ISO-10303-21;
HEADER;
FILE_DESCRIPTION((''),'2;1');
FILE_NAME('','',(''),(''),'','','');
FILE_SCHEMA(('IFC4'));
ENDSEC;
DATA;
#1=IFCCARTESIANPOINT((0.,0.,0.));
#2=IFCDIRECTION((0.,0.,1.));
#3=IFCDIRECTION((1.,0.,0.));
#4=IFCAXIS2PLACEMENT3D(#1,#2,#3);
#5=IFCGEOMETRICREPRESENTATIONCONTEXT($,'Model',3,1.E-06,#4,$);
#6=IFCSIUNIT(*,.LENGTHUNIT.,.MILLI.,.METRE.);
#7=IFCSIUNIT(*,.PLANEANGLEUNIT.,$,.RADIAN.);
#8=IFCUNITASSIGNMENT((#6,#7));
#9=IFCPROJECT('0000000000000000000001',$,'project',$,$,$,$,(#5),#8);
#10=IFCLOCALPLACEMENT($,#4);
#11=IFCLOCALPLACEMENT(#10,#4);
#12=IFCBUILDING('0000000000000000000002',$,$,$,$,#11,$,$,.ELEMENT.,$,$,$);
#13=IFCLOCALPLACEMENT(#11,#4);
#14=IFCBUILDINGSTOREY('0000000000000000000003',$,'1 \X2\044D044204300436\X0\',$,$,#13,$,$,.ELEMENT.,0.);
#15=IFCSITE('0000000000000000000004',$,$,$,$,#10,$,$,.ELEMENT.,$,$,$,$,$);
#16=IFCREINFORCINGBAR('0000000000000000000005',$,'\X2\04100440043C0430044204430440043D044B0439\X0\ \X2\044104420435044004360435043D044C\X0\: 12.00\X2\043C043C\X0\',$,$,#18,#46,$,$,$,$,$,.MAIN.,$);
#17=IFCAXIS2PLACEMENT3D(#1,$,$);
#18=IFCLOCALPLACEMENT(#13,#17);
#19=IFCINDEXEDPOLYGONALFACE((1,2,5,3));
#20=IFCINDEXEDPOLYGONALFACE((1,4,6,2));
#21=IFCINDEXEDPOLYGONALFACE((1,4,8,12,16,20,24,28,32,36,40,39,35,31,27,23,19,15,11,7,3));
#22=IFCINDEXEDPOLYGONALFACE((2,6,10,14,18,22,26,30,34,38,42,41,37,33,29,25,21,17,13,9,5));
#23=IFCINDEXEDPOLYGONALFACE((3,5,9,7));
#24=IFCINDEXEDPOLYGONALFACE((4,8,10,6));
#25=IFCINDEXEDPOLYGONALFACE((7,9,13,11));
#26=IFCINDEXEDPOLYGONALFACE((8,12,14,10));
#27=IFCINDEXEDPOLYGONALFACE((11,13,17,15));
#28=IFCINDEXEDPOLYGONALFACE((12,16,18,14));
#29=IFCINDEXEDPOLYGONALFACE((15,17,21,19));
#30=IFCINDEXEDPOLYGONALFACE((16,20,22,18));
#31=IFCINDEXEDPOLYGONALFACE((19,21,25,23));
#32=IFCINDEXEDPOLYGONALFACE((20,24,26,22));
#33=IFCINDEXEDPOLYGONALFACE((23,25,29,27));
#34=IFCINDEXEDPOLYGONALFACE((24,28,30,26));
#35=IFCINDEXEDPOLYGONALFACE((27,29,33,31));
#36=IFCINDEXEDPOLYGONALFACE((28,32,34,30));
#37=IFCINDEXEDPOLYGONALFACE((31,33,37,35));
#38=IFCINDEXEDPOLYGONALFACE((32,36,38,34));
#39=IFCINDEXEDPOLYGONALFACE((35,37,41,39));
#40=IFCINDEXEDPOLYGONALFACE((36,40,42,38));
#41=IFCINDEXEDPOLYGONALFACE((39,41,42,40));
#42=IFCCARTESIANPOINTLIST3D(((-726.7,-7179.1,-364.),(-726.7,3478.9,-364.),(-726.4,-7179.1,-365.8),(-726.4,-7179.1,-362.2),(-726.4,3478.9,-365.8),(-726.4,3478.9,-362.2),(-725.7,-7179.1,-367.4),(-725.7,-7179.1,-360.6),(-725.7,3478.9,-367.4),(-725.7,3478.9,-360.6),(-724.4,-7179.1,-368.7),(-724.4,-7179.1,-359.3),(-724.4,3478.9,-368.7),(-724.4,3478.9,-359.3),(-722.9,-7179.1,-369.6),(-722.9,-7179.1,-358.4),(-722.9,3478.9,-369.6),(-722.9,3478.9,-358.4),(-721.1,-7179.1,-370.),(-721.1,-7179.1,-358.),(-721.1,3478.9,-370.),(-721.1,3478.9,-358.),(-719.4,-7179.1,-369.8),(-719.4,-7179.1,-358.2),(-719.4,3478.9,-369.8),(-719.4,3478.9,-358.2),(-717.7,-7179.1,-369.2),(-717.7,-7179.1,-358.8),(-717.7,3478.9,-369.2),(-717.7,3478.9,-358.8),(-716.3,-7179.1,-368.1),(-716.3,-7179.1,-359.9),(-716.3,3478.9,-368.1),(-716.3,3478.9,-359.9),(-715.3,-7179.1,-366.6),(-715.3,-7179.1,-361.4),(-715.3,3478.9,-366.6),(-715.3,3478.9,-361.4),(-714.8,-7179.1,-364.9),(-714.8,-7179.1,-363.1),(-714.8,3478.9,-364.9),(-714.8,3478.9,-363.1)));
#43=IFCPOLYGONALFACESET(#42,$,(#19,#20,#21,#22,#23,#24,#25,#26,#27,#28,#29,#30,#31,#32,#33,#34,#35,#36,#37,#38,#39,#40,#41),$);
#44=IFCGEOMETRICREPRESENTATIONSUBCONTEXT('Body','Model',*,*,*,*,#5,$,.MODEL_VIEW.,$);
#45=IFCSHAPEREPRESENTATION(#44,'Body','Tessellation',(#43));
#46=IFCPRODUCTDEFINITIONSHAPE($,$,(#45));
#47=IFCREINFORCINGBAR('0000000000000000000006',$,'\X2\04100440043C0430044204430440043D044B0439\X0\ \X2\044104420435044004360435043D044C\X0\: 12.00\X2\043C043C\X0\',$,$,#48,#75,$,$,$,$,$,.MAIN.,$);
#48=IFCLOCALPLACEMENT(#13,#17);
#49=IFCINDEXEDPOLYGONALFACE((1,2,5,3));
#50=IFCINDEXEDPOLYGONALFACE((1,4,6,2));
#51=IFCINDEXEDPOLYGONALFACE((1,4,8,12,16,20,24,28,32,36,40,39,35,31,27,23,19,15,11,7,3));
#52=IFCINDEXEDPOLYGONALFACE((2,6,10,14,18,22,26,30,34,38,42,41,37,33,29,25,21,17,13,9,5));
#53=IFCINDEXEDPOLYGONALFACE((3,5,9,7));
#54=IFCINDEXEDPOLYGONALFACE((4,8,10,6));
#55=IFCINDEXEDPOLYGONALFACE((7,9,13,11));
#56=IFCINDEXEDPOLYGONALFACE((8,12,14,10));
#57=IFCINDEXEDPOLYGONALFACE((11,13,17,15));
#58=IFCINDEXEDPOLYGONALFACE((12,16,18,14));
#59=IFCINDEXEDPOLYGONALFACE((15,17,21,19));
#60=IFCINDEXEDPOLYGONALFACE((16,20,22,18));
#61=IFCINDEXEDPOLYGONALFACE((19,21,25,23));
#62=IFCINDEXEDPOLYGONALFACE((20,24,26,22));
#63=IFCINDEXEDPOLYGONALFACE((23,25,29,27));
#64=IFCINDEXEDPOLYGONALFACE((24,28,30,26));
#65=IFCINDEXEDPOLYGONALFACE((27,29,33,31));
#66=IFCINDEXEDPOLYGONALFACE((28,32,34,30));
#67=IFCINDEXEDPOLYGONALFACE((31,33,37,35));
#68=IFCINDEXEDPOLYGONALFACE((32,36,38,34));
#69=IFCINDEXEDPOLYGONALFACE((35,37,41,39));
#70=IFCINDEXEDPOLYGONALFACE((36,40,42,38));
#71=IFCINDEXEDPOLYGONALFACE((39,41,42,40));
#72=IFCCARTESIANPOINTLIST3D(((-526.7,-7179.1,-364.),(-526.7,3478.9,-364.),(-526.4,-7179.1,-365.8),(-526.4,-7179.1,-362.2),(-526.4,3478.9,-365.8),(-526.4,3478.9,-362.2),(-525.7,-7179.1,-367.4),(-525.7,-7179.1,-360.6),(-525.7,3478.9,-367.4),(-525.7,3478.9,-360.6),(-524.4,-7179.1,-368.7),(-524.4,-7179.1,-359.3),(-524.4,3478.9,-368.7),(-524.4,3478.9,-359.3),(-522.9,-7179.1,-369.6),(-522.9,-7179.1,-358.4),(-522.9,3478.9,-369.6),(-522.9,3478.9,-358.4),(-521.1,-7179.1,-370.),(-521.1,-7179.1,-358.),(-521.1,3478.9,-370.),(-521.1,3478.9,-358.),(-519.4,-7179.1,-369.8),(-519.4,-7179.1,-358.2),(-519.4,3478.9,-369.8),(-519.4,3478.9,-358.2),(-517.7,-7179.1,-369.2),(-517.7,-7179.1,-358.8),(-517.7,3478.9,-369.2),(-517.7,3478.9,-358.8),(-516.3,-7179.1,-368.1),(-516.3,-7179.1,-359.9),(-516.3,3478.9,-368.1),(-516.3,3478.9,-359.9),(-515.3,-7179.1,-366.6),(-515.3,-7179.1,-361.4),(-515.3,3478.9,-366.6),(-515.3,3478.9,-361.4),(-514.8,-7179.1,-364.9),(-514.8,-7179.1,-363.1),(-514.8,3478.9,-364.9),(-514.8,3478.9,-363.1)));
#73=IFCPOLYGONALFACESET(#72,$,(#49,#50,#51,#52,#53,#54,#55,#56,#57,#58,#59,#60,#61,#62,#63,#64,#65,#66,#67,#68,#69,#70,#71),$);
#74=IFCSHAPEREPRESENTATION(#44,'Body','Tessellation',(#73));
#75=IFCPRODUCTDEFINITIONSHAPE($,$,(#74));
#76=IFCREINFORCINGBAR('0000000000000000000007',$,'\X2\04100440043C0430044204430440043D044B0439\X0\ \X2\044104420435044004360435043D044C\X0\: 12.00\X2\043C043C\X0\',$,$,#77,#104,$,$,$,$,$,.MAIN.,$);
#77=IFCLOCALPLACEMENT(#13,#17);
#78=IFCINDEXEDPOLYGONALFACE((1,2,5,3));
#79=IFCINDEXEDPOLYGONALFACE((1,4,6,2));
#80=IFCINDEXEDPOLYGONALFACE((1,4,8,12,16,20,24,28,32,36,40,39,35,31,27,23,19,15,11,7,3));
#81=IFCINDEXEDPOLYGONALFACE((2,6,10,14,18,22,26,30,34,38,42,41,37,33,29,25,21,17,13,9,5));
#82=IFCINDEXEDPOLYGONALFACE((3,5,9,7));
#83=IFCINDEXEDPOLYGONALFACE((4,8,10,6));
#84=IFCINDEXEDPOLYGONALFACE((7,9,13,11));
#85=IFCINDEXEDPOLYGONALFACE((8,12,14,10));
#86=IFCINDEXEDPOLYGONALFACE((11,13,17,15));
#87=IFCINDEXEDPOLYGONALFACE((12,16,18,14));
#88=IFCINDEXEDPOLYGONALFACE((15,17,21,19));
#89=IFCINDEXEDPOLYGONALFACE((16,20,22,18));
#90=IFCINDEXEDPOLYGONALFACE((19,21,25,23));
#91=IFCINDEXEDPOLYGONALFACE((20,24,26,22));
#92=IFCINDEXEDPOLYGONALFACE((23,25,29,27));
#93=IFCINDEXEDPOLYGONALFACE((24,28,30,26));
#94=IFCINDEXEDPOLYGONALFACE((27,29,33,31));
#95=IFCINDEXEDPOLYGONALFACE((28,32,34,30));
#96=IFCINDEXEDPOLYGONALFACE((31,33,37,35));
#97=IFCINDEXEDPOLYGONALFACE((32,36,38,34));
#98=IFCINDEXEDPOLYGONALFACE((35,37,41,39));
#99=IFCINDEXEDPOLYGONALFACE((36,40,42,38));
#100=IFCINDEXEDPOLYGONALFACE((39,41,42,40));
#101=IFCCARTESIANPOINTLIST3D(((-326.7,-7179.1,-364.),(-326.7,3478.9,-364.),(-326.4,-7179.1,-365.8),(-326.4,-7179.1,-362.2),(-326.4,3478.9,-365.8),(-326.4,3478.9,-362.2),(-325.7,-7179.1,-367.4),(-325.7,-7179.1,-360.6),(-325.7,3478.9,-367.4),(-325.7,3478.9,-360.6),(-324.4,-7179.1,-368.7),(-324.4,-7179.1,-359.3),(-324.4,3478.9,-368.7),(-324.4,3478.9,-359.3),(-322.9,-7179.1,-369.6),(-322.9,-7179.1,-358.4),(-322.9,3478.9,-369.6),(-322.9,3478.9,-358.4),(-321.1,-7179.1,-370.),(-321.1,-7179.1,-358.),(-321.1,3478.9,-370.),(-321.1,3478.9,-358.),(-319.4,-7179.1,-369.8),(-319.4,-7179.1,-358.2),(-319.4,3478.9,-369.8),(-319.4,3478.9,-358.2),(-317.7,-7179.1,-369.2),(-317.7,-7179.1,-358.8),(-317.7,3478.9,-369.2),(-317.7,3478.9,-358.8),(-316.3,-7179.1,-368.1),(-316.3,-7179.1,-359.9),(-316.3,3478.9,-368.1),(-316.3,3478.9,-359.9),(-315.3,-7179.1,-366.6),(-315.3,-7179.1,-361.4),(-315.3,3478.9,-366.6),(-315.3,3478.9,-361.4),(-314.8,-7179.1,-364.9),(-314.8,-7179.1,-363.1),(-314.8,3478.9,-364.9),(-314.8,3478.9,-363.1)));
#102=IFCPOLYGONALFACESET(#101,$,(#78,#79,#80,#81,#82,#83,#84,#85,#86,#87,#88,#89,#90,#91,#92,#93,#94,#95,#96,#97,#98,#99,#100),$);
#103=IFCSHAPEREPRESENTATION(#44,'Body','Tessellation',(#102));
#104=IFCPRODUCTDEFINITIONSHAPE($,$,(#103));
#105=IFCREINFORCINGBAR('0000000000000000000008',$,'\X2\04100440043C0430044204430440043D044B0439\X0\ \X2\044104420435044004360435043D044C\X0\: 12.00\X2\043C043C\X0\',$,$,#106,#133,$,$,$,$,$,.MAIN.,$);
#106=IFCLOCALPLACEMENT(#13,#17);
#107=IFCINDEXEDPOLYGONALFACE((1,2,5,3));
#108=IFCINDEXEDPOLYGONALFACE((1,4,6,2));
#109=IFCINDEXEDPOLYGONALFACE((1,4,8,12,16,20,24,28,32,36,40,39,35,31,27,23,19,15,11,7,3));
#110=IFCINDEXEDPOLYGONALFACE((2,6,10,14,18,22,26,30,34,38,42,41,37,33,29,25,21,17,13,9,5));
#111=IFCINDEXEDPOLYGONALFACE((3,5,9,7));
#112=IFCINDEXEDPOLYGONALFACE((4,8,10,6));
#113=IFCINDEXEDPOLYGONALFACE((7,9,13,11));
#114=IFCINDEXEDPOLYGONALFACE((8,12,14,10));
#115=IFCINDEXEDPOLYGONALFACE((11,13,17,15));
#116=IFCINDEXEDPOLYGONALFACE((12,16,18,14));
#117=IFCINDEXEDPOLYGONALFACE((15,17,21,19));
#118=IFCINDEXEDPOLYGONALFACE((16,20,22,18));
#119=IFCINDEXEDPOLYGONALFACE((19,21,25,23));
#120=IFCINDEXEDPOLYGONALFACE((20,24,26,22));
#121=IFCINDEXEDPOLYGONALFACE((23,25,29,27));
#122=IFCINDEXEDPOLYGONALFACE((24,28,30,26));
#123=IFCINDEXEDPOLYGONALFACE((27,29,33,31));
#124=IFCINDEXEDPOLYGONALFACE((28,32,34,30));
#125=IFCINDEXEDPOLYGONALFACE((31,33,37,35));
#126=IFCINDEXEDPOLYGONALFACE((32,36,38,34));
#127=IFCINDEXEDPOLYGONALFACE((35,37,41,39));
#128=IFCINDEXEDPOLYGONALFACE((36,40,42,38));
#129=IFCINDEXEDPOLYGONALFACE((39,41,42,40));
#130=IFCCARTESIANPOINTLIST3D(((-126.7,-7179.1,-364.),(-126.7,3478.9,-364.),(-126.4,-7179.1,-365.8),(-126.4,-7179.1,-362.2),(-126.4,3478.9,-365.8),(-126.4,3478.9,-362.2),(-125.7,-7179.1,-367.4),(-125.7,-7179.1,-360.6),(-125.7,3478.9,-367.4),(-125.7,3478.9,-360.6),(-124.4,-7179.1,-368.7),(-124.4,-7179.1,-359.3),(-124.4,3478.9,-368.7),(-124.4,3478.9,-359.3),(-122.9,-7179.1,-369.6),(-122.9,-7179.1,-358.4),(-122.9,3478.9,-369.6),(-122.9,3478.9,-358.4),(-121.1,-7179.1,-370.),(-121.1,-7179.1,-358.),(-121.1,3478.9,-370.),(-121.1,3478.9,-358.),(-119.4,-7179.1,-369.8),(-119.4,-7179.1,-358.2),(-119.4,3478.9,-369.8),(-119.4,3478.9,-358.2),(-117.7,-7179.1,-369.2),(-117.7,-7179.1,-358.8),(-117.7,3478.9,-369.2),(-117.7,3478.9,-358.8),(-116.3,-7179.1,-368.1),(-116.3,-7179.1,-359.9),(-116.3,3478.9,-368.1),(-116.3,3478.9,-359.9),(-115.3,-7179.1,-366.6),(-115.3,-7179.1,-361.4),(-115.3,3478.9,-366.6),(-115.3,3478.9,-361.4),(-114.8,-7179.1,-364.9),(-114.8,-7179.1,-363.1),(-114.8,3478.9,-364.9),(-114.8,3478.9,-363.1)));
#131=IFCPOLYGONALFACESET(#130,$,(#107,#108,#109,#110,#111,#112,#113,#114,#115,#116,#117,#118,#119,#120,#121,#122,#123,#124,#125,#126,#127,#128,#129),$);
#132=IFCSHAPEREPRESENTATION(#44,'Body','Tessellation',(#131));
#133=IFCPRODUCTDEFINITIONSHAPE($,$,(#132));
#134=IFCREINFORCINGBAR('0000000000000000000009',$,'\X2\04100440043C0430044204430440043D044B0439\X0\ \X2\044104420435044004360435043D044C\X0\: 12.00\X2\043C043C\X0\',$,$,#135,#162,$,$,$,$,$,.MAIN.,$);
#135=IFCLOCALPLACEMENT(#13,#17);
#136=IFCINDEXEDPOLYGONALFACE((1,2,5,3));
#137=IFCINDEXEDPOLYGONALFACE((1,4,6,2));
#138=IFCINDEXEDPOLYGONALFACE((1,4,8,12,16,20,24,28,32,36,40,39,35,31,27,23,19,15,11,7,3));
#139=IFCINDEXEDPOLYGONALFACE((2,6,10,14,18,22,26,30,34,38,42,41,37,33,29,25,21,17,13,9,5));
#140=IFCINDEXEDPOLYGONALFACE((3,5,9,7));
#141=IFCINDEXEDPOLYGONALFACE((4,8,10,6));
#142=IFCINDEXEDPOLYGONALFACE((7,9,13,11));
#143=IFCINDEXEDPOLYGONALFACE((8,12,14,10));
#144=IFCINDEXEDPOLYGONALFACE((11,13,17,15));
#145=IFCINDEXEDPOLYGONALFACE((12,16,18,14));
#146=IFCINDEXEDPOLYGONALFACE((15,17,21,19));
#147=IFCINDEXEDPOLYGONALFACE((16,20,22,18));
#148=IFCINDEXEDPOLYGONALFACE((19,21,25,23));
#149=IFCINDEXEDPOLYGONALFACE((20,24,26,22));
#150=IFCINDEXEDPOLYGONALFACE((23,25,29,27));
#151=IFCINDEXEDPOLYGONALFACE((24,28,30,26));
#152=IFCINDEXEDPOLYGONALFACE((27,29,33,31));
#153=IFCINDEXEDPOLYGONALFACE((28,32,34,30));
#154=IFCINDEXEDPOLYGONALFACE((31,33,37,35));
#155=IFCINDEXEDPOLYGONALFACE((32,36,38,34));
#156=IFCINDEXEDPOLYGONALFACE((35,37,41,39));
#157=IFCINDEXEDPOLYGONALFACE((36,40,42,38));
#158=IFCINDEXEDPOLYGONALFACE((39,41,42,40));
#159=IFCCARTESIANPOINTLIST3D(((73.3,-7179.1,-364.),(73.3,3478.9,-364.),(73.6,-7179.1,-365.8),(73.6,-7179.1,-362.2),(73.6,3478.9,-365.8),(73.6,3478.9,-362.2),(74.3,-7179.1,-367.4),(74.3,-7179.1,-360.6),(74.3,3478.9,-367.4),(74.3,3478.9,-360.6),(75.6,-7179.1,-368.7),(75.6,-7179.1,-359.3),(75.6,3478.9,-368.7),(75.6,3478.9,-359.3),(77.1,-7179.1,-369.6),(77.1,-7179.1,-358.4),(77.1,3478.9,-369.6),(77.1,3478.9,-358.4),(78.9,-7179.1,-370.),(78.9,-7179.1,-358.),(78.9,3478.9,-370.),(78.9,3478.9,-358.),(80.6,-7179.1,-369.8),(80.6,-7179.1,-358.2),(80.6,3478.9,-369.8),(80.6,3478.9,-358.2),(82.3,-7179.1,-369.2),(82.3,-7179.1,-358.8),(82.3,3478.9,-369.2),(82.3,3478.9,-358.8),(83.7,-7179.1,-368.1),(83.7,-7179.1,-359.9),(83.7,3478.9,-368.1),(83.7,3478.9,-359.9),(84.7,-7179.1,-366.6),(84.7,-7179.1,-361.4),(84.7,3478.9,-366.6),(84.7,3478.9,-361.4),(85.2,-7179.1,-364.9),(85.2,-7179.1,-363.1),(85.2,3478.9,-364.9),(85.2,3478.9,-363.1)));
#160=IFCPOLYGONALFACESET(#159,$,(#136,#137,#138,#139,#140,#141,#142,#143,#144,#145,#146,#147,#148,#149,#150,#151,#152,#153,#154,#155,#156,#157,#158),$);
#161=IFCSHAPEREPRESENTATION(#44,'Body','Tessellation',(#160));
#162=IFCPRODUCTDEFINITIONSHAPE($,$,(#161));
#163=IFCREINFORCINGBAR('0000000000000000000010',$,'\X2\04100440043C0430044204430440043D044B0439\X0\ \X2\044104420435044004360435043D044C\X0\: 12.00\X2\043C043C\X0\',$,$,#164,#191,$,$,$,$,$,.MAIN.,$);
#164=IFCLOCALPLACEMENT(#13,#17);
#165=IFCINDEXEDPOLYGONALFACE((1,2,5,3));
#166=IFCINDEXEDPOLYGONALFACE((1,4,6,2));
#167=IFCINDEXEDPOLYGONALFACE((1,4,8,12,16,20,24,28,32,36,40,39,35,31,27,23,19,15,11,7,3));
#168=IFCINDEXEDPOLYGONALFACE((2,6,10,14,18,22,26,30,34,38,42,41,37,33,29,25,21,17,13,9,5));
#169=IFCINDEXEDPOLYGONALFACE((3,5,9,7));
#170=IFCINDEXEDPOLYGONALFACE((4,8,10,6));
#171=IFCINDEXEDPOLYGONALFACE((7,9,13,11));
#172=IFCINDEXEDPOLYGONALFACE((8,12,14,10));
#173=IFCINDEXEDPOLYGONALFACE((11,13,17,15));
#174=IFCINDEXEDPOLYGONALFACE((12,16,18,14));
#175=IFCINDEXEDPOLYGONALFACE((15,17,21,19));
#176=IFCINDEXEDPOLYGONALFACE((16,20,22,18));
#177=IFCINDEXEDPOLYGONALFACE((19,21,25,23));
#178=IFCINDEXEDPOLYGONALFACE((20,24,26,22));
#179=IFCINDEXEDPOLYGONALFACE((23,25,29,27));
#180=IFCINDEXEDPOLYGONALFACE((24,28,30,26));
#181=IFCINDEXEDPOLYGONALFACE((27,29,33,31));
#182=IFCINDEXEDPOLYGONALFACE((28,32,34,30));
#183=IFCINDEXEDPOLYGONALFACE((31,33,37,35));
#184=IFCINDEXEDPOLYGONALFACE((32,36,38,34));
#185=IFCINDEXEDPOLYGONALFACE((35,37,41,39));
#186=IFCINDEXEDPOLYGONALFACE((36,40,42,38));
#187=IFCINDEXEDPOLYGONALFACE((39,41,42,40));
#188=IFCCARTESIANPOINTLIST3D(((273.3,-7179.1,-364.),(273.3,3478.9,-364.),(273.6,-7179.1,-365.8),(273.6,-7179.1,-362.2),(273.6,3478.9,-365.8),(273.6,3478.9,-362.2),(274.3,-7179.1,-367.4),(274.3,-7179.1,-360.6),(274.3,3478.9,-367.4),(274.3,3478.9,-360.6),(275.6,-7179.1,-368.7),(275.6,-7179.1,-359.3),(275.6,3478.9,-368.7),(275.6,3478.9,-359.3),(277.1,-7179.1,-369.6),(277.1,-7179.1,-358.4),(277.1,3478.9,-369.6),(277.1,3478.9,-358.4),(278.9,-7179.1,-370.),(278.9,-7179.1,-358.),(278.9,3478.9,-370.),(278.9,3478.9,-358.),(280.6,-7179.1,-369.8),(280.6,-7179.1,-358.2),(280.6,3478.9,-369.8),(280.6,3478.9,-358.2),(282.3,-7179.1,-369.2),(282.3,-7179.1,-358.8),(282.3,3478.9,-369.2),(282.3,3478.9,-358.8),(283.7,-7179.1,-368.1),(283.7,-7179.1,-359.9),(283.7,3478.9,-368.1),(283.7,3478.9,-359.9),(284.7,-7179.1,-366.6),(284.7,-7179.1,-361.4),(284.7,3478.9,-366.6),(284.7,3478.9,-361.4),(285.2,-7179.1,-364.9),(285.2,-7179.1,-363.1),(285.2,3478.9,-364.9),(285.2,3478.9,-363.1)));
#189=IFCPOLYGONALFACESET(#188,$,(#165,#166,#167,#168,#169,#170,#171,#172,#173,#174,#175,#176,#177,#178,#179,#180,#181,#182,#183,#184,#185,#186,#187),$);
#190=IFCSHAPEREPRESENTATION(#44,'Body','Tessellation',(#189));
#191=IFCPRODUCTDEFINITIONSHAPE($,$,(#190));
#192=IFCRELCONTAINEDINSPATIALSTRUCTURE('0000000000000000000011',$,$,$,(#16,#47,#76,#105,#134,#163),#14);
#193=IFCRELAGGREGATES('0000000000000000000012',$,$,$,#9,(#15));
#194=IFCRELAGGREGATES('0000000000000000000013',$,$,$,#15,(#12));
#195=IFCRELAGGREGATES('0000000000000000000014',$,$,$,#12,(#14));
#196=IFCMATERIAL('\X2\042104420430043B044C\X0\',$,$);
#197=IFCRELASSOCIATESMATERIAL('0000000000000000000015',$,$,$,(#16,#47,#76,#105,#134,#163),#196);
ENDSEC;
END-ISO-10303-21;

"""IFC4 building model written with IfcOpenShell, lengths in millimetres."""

from ifc_helpers import new_model, entity, si_unit, origin_with_axes, place, context, subcontext, project, spatial, source, transform, mapped, material, element, save


model = new_model("IFC4")

# Units and contexts
model_context = context("Model", 3, precision=1e-06, world=origin_with_axes())
body_context = subcontext(model_context, "Body", "Model", "MODEL_VIEW")
ifc_project = project(units=[si_unit("LENGTHUNIT", "METRE", prefix="MILLI"), si_unit("PLANEANGLEUNIT", "RADIAN")], contexts=[model_context])

# Site, building, storey
site_placement = place(None, origin_with_axes())
site = spatial("IfcSite", under=ifc_project, at=site_placement, CompositionType="ELEMENT")
building_placement = place(site_placement, origin_with_axes())
building = spatial("IfcBuilding", under=site, at=building_placement, CompositionType="ELEMENT")
storey_placement = place(building_placement, origin_with_axes())
storey = spatial("IfcBuildingStorey", under=building, at=storey_placement, Name="1 этаж", CompositionType="ELEMENT", Elevation=0.0)

# Reinforcing bars
ifc_material = material(Name="Сталь")
shared_shape_1 = source(origin_with_axes(), body_context, "Body", "AdvancedSweptSolid", [
    entity("IfcSweptDiskSolid", entity("IfcIndexedPolyCurve", entity("IfcCartesianPointList3D", [[0.0, 0.0, 0.0], [10658.0, 0.0, 0.0]]), [entity("IfcLineIndex", [1, 2])]), 6.0),
])
reinforcing_bar_1_placement = place(storey_placement, origin_with_axes())
element("IfcReinforcingBar", 1, at=reinforcing_bar_1_placement, inside=storey, material=ifc_material, Name="Арматурный стержень: 12.00мм", PredefinedType="MAIN", context=body_context, shape_type="MappedRepresentation", body=[
    mapped(shared_shape_1, transform((-720.7, -7179.1, -364.0), x_axis=(0.0, 1.0, 0.0), y_axis=(-1.0, 0.0, 0.0), z_axis=(0.0, 0.0, 1.0), scale=1.0)),
])
reinforcing_bar_2_placement = place(storey_placement, origin_with_axes())
element("IfcReinforcingBar", 2, at=reinforcing_bar_2_placement, inside=storey, material=ifc_material, Name="Арматурный стержень: 12.00мм", PredefinedType="MAIN", context=body_context, shape_type="MappedRepresentation", body=[
    mapped(shared_shape_1, transform((-520.7, -7179.1, -364.0), x_axis=(0.0, 1.0, 0.0), y_axis=(-1.0, 0.0, 0.0), z_axis=(0.0, 0.0, 1.0), scale=1.0)),
])
reinforcing_bar_3_placement = place(storey_placement, origin_with_axes())
element("IfcReinforcingBar", 3, at=reinforcing_bar_3_placement, inside=storey, material=ifc_material, Name="Арматурный стержень: 12.00мм", PredefinedType="MAIN", context=body_context, shape_type="MappedRepresentation", body=[
    mapped(shared_shape_1, transform((-320.7, -7179.1, -364.0), x_axis=(0.0, 1.0, 0.0), y_axis=(-1.0, 0.0, 0.0), z_axis=(0.0, 0.0, 1.0), scale=1.0)),
])
reinforcing_bar_4_placement = place(storey_placement, origin_with_axes())
element("IfcReinforcingBar", 4, at=reinforcing_bar_4_placement, inside=storey, material=ifc_material, Name="Арматурный стержень: 12.00мм", PredefinedType="MAIN", context=body_context, shape_type="MappedRepresentation", body=[
    mapped(shared_shape_1, transform((-120.7, -7179.1, -364.0), x_axis=(0.0, 1.0, 0.0), y_axis=(-1.0, 0.0, 0.0), z_axis=(0.0, 0.0, 1.0), scale=1.0)),
])
reinforcing_bar_5_placement = place(storey_placement, origin_with_axes())
element("IfcReinforcingBar", 5, at=reinforcing_bar_5_placement, inside=storey, material=ifc_material, Name="Арматурный стержень: 12.00мм", PredefinedType="MAIN", context=body_context, shape_type="MappedRepresentation", body=[
    mapped(shared_shape_1, transform((79.3, -7179.1, -364.0), x_axis=(0.0, 1.0, 0.0), y_axis=(-1.0, 0.0, 0.0), z_axis=(0.0, 0.0, 1.0), scale=1.0)),
])
reinforcing_bar_6_placement = place(storey_placement, origin_with_axes())
element("IfcReinforcingBar", 6, at=reinforcing_bar_6_placement, inside=storey, material=ifc_material, Name="Арматурный стержень: 12.00мм", PredefinedType="MAIN", context=body_context, shape_type="MappedRepresentation", body=[
    mapped(shared_shape_1, transform((279.3, -7179.1, -364.0), x_axis=(0.0, 1.0, 0.0), y_axis=(-1.0, 0.0, 0.0), z_axis=(0.0, 0.0, 1.0), scale=1.0)),
])

save(model, "model.ifc")
